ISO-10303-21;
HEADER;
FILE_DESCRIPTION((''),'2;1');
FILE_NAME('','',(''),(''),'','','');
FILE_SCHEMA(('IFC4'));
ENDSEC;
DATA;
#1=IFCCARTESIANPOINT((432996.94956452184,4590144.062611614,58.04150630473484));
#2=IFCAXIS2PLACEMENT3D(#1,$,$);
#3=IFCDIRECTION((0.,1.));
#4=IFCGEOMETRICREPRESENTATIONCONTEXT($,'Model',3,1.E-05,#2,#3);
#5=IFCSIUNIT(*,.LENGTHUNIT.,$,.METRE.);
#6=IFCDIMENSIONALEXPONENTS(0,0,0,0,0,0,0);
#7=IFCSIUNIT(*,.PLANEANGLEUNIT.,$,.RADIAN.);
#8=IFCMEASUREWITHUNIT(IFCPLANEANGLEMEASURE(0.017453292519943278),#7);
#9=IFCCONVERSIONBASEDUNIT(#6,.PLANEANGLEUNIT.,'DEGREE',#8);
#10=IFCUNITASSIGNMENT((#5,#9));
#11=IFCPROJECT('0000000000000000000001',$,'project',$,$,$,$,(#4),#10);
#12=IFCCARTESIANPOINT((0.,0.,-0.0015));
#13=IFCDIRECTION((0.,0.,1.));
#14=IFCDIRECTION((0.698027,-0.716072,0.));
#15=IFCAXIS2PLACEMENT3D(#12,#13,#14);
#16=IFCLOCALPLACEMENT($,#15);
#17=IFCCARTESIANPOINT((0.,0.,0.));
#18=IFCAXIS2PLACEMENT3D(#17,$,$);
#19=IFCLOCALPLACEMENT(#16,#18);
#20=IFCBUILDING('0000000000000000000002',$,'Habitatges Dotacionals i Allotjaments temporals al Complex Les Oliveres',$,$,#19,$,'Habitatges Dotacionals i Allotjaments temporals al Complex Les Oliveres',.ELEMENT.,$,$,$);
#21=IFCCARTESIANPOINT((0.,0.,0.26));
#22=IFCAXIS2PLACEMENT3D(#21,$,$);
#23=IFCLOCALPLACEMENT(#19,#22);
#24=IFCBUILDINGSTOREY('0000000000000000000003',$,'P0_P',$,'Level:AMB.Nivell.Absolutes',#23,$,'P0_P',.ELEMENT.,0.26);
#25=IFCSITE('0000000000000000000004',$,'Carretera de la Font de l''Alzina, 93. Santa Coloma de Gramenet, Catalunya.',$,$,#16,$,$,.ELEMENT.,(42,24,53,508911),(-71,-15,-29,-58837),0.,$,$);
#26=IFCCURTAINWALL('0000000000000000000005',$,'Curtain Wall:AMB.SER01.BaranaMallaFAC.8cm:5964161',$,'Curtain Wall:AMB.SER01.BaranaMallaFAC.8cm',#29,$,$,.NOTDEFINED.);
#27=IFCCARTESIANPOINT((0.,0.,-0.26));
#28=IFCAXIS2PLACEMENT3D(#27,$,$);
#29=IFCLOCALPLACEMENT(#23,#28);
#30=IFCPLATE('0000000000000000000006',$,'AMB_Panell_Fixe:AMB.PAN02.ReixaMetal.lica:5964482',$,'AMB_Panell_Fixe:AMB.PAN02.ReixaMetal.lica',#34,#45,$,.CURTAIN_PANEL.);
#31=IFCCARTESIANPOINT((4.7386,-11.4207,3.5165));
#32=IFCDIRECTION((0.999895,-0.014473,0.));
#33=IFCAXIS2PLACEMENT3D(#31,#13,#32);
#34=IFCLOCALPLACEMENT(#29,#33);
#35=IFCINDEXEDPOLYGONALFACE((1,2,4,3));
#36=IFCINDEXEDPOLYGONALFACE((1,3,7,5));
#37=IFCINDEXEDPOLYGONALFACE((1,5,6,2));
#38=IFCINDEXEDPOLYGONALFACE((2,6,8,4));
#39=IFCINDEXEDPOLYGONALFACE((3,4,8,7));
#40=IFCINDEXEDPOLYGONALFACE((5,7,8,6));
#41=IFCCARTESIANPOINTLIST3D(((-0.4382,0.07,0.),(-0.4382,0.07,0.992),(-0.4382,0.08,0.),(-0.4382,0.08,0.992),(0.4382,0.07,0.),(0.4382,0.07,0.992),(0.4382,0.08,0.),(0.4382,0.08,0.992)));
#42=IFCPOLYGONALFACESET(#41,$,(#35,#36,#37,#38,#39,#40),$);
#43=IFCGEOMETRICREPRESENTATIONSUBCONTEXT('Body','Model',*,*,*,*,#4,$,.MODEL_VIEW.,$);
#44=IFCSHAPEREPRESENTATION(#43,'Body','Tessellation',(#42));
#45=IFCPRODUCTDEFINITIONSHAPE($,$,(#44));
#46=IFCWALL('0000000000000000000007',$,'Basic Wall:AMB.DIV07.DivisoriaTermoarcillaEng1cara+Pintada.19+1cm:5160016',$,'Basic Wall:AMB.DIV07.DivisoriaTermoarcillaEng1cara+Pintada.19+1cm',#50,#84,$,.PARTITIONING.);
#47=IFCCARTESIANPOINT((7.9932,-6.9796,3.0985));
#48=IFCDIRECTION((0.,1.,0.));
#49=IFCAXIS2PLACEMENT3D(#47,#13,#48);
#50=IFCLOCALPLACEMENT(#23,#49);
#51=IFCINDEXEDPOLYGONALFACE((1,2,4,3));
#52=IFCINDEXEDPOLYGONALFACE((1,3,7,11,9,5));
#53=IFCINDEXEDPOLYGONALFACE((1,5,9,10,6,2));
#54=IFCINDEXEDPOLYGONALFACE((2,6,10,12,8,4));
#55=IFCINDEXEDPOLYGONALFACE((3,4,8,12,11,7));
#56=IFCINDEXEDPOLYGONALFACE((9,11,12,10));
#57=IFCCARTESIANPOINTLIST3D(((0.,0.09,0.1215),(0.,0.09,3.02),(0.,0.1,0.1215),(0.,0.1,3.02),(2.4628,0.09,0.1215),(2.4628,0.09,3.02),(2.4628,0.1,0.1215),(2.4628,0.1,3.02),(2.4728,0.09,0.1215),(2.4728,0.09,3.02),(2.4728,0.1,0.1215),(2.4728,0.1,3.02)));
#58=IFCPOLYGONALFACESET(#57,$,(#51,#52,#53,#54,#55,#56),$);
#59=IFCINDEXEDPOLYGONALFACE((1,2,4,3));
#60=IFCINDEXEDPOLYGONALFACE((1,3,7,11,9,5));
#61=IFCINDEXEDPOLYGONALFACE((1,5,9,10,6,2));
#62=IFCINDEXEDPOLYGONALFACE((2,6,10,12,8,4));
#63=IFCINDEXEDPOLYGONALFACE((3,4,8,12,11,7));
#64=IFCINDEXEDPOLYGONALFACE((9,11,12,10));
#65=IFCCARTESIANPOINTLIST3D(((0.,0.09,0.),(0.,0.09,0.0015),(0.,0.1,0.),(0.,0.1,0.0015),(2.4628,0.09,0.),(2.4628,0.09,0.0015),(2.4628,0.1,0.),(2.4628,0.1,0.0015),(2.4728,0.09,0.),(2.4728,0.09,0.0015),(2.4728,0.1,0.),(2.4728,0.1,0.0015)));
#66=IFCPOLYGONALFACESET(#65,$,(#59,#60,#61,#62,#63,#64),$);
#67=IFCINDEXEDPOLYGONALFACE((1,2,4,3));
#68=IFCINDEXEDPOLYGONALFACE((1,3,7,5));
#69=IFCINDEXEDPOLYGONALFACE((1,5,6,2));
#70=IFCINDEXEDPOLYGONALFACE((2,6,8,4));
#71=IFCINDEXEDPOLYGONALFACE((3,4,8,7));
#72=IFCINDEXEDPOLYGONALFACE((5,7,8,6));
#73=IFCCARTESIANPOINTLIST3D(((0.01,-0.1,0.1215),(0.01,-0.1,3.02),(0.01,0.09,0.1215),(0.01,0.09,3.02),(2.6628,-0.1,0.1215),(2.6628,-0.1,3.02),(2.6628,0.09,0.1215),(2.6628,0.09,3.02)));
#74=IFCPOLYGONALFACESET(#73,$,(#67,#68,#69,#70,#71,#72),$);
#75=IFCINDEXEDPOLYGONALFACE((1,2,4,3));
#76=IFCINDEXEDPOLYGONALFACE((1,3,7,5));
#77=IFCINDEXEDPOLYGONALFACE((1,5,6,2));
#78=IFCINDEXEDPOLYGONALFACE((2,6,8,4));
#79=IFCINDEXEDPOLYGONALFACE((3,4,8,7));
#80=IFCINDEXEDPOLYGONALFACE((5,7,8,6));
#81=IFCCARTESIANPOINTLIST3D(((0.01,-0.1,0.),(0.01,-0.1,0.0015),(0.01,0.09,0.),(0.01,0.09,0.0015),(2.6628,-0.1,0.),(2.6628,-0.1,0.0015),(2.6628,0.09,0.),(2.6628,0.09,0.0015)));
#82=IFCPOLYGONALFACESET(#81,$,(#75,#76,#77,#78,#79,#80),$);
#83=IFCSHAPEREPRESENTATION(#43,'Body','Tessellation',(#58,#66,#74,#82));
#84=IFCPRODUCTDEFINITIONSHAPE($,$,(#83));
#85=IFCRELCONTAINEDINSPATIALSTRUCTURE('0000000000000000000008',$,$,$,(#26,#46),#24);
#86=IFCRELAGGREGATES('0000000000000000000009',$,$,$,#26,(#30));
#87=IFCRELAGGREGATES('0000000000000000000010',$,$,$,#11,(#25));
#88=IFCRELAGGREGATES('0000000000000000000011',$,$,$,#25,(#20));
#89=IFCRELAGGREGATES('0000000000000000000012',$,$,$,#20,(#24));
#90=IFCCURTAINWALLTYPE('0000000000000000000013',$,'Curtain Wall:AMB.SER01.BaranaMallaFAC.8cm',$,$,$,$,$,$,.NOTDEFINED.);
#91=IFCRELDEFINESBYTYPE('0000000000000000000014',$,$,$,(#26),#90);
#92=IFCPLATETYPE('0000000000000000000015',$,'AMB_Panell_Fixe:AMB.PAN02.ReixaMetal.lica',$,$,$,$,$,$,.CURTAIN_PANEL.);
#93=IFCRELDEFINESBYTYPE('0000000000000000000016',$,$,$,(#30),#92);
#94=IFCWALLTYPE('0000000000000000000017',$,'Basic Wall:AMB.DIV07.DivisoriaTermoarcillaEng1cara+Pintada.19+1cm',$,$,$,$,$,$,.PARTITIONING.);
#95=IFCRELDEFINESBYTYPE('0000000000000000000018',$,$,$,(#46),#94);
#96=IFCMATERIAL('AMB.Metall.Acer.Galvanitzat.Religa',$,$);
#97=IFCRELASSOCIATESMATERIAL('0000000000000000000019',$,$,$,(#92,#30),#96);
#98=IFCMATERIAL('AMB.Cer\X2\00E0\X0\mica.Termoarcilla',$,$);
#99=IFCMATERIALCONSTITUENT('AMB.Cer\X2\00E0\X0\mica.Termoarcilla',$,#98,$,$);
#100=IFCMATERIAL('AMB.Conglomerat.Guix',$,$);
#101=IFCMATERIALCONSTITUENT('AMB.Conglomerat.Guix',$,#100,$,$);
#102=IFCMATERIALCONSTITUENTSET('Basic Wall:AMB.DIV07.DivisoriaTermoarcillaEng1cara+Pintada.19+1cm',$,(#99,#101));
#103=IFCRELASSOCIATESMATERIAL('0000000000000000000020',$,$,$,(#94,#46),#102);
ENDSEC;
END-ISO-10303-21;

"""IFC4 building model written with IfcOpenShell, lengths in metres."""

from ifc_helpers import new_model, entity, si_unit, converted_unit, direction, frame, origin, place, context, subcontext, project, spatial, indexed_curve, outline, extrude, source, transform, mapped, material, constituent, constituent_set, type_object, type_shapes, element, aggregate, save


model = new_model("IFC4")

# Units and contexts
model_context = context("Model", 3, precision=1e-05, world=frame((432996.94956452184, 4590144.062611614, 58.04150630473484)), true_north=direction((0.0, 1.0)))
body_context = subcontext(model_context, "Body", "Model", "MODEL_VIEW")
ifc_project = project(units=[si_unit("LENGTHUNIT", "METRE"), converted_unit("PLANEANGLEUNIT", "DEGREE", entity("IfcPlaneAngleMeasure", 0.017453292519943278), si_unit("PLANEANGLEUNIT", "RADIAN"), dimensions=[0, 0, 0, 0, 0, 0, 0])], contexts=[model_context])

# Site, building, storey
site_placement = place(None, frame((0.0, 0.0, -0.0015), z_axis=(0.0, 0.0, 1.0), x_axis=(0.698027, -0.716072, 0.0)))
site = spatial("IfcSite", under=ifc_project, at=site_placement, Name="Carretera de la Font de l'Alzina, 93. Santa Coloma de Gramenet, Catalunya.", CompositionType="ELEMENT", RefLatitude=(42, 24, 53, 508911), RefLongitude=(-71, -15, -29, -58837), RefElevation=0.0)
building_placement = place(site_placement, origin())
building = spatial("IfcBuilding", under=site, at=building_placement, Name="Habitatges Dotacionals i Allotjaments temporals al Complex Les Oliveres", LongName="Habitatges Dotacionals i Allotjaments temporals al Complex Les Oliveres", CompositionType="ELEMENT")
storey_placement = place(building_placement, frame((0.0, 0.0, 0.26)))
storey = spatial("IfcBuildingStorey", under=building, at=storey_placement, Name="P0_P", ObjectType="Level:AMB.Nivell.Absolutes", LongName="P0_P", CompositionType="ELEMENT", Elevation=0.26)

# Curtain wall, plate
curtain_wall_type_1 = type_object("IfcCurtainWallType", Name="Curtain Wall:AMB.SER01.BaranaMallaFAC.8cm", PredefinedType="NOTDEFINED")
curtain_wall_1_placement = place(storey_placement, frame((0.0, 0.0, -0.26)))
curtain_wall_1 = element("IfcCurtainWall", 1, at=curtain_wall_1_placement, inside=storey, type_object=curtain_wall_type_1, Name="Curtain Wall:AMB.SER01.BaranaMallaFAC.8cm:5964161", ObjectType="Curtain Wall:AMB.SER01.BaranaMallaFAC.8cm", PredefinedType="NOTDEFINED")
ifc_material_1 = material(Name="AMB.Metall.Acer.Galvanitzat.Religa")
plate_type_1 = type_object("IfcPlateType", Name="AMB_Panell_Fixe:AMB.PAN02.ReixaMetal.lica", PredefinedType="CURTAIN_PANEL", material=ifc_material_1)
shared_shape_1 = source(origin(), body_context, "Body", "SweptSolid", [
    extrude(outline(indexed_curve([(-0.005, -0.4382), (0.005, -0.4382), (0.005, 0.4382), (-0.005, 0.4382), (-0.005, -0.4382)], self_intersect=False)), frame((0.0, 0.075, 0.0), z_axis=(0.0, 0.0, 1.0), x_axis=(0.0, 1.0, 0.0)), (0.0, 0.0, 1.0), 0.992),
])
type_shapes(plate_type_1, [shared_shape_1])
plate_1_placement = place(curtain_wall_1_placement, frame((4.7386, -11.4207, 3.5165), z_axis=(0.0, 0.0, 1.0), x_axis=(0.999895, -0.014473, 0.0)))
plate_1 = element("IfcPlate", 2, at=plate_1_placement, type_object=plate_type_1, material=ifc_material_1, Name="AMB_Panell_Fixe:AMB.PAN02.ReixaMetal.lica:5964482", ObjectType="AMB_Panell_Fixe:AMB.PAN02.ReixaMetal.lica", PredefinedType="CURTAIN_PANEL", context=body_context, shape_type="MappedRepresentation", body=[
    mapped(shared_shape_1, transform((0.0, 0.0, 0.0), scale=1.0)),
])
aggregate(curtain_wall_1, [plate_1])

# Wall
ifc_material_2 = material(Name="AMB.Ceràmica.Termoarcilla")
ifc_constituent_1 = constituent(ifc_material_2, Name="AMB.Ceràmica.Termoarcilla")
ifc_material_3 = material(Name="AMB.Conglomerat.Guix")
ifc_constituent_2 = constituent(ifc_material_3, Name="AMB.Conglomerat.Guix")
ifc_constituent_set_1 = constituent_set(constituents=[ifc_constituent_1, ifc_constituent_2], Name="Basic Wall:AMB.DIV07.DivisoriaTermoarcillaEng1cara+Pintada.19+1cm")
wall_type = type_object("IfcWallType", Name="Basic Wall:AMB.DIV07.DivisoriaTermoarcillaEng1cara+Pintada.19+1cm", PredefinedType="PARTITIONING", material=ifc_constituent_set_1)
wall_placement = place(storey_placement, frame((7.9932, -6.9796, 3.0985), z_axis=(0.0, 0.0, 1.0), x_axis=(0.0, 1.0, 0.0)))
element("IfcWall", 3, at=wall_placement, inside=storey, type_object=wall_type, material=ifc_constituent_set_1, Name="Basic Wall:AMB.DIV07.DivisoriaTermoarcillaEng1cara+Pintada.19+1cm:5160016", ObjectType="Basic Wall:AMB.DIV07.DivisoriaTermoarcillaEng1cara+Pintada.19+1cm", PredefinedType="PARTITIONING", context=body_context, shape_type="SweptSolid", body=[
    extrude(outline(indexed_curve([(-1.4492, -1.6452), (1.4492, -1.6452), (1.4492, 0.8176), (1.4492, 0.8276), (-1.4492, 0.8276), (-1.4492, 0.8176), (-1.4492, -1.6452)], self_intersect=False)), frame((1.6452, 0.1, 1.5708), z_axis=(0.0, -1.0, 0.0), x_axis=(0.0, 0.0, -1.0)), (0.0, 0.0, 1.0), 0.01),
    extrude(outline(indexed_curve([(-0.0008, -0.8276), (0.0008, -0.8276), (0.0008, -0.8176), (0.0008, 1.6452), (-0.0008, 1.6452), (-0.0008, -0.8176), (-0.0008, -0.8276)], self_intersect=False)), frame((1.6452, 0.1, 0.0008), z_axis=(0.0, -1.0, 0.0), x_axis=(0.0, 0.0, 1.0)), (0.0, 0.0, 1.0), 0.01),
    extrude(outline(indexed_curve([(-1.4492, -1.3264), (1.4492, -1.3264), (1.4492, 1.3264), (-1.4492, 1.3264), (-1.4492, -1.3264)], self_intersect=False)), frame((1.3364, 0.09, 1.5708), z_axis=(0.0, -1.0, 0.0), x_axis=(0.0, 0.0, -1.0)), (0.0, 0.0, 1.0), 0.19),
    extrude(outline(indexed_curve([(-0.0008, -1.3264), (0.0008, -1.3264), (0.0008, 1.3264), (-0.0008, 1.3264), (-0.0008, -1.3264)], self_intersect=False)), frame((1.3364, 0.09, 0.0008), z_axis=(0.0, -1.0, 0.0), x_axis=(0.0, 0.0, 1.0)), (0.0, 0.0, 1.0), 0.19),
])

save(model, "model.ifc")
